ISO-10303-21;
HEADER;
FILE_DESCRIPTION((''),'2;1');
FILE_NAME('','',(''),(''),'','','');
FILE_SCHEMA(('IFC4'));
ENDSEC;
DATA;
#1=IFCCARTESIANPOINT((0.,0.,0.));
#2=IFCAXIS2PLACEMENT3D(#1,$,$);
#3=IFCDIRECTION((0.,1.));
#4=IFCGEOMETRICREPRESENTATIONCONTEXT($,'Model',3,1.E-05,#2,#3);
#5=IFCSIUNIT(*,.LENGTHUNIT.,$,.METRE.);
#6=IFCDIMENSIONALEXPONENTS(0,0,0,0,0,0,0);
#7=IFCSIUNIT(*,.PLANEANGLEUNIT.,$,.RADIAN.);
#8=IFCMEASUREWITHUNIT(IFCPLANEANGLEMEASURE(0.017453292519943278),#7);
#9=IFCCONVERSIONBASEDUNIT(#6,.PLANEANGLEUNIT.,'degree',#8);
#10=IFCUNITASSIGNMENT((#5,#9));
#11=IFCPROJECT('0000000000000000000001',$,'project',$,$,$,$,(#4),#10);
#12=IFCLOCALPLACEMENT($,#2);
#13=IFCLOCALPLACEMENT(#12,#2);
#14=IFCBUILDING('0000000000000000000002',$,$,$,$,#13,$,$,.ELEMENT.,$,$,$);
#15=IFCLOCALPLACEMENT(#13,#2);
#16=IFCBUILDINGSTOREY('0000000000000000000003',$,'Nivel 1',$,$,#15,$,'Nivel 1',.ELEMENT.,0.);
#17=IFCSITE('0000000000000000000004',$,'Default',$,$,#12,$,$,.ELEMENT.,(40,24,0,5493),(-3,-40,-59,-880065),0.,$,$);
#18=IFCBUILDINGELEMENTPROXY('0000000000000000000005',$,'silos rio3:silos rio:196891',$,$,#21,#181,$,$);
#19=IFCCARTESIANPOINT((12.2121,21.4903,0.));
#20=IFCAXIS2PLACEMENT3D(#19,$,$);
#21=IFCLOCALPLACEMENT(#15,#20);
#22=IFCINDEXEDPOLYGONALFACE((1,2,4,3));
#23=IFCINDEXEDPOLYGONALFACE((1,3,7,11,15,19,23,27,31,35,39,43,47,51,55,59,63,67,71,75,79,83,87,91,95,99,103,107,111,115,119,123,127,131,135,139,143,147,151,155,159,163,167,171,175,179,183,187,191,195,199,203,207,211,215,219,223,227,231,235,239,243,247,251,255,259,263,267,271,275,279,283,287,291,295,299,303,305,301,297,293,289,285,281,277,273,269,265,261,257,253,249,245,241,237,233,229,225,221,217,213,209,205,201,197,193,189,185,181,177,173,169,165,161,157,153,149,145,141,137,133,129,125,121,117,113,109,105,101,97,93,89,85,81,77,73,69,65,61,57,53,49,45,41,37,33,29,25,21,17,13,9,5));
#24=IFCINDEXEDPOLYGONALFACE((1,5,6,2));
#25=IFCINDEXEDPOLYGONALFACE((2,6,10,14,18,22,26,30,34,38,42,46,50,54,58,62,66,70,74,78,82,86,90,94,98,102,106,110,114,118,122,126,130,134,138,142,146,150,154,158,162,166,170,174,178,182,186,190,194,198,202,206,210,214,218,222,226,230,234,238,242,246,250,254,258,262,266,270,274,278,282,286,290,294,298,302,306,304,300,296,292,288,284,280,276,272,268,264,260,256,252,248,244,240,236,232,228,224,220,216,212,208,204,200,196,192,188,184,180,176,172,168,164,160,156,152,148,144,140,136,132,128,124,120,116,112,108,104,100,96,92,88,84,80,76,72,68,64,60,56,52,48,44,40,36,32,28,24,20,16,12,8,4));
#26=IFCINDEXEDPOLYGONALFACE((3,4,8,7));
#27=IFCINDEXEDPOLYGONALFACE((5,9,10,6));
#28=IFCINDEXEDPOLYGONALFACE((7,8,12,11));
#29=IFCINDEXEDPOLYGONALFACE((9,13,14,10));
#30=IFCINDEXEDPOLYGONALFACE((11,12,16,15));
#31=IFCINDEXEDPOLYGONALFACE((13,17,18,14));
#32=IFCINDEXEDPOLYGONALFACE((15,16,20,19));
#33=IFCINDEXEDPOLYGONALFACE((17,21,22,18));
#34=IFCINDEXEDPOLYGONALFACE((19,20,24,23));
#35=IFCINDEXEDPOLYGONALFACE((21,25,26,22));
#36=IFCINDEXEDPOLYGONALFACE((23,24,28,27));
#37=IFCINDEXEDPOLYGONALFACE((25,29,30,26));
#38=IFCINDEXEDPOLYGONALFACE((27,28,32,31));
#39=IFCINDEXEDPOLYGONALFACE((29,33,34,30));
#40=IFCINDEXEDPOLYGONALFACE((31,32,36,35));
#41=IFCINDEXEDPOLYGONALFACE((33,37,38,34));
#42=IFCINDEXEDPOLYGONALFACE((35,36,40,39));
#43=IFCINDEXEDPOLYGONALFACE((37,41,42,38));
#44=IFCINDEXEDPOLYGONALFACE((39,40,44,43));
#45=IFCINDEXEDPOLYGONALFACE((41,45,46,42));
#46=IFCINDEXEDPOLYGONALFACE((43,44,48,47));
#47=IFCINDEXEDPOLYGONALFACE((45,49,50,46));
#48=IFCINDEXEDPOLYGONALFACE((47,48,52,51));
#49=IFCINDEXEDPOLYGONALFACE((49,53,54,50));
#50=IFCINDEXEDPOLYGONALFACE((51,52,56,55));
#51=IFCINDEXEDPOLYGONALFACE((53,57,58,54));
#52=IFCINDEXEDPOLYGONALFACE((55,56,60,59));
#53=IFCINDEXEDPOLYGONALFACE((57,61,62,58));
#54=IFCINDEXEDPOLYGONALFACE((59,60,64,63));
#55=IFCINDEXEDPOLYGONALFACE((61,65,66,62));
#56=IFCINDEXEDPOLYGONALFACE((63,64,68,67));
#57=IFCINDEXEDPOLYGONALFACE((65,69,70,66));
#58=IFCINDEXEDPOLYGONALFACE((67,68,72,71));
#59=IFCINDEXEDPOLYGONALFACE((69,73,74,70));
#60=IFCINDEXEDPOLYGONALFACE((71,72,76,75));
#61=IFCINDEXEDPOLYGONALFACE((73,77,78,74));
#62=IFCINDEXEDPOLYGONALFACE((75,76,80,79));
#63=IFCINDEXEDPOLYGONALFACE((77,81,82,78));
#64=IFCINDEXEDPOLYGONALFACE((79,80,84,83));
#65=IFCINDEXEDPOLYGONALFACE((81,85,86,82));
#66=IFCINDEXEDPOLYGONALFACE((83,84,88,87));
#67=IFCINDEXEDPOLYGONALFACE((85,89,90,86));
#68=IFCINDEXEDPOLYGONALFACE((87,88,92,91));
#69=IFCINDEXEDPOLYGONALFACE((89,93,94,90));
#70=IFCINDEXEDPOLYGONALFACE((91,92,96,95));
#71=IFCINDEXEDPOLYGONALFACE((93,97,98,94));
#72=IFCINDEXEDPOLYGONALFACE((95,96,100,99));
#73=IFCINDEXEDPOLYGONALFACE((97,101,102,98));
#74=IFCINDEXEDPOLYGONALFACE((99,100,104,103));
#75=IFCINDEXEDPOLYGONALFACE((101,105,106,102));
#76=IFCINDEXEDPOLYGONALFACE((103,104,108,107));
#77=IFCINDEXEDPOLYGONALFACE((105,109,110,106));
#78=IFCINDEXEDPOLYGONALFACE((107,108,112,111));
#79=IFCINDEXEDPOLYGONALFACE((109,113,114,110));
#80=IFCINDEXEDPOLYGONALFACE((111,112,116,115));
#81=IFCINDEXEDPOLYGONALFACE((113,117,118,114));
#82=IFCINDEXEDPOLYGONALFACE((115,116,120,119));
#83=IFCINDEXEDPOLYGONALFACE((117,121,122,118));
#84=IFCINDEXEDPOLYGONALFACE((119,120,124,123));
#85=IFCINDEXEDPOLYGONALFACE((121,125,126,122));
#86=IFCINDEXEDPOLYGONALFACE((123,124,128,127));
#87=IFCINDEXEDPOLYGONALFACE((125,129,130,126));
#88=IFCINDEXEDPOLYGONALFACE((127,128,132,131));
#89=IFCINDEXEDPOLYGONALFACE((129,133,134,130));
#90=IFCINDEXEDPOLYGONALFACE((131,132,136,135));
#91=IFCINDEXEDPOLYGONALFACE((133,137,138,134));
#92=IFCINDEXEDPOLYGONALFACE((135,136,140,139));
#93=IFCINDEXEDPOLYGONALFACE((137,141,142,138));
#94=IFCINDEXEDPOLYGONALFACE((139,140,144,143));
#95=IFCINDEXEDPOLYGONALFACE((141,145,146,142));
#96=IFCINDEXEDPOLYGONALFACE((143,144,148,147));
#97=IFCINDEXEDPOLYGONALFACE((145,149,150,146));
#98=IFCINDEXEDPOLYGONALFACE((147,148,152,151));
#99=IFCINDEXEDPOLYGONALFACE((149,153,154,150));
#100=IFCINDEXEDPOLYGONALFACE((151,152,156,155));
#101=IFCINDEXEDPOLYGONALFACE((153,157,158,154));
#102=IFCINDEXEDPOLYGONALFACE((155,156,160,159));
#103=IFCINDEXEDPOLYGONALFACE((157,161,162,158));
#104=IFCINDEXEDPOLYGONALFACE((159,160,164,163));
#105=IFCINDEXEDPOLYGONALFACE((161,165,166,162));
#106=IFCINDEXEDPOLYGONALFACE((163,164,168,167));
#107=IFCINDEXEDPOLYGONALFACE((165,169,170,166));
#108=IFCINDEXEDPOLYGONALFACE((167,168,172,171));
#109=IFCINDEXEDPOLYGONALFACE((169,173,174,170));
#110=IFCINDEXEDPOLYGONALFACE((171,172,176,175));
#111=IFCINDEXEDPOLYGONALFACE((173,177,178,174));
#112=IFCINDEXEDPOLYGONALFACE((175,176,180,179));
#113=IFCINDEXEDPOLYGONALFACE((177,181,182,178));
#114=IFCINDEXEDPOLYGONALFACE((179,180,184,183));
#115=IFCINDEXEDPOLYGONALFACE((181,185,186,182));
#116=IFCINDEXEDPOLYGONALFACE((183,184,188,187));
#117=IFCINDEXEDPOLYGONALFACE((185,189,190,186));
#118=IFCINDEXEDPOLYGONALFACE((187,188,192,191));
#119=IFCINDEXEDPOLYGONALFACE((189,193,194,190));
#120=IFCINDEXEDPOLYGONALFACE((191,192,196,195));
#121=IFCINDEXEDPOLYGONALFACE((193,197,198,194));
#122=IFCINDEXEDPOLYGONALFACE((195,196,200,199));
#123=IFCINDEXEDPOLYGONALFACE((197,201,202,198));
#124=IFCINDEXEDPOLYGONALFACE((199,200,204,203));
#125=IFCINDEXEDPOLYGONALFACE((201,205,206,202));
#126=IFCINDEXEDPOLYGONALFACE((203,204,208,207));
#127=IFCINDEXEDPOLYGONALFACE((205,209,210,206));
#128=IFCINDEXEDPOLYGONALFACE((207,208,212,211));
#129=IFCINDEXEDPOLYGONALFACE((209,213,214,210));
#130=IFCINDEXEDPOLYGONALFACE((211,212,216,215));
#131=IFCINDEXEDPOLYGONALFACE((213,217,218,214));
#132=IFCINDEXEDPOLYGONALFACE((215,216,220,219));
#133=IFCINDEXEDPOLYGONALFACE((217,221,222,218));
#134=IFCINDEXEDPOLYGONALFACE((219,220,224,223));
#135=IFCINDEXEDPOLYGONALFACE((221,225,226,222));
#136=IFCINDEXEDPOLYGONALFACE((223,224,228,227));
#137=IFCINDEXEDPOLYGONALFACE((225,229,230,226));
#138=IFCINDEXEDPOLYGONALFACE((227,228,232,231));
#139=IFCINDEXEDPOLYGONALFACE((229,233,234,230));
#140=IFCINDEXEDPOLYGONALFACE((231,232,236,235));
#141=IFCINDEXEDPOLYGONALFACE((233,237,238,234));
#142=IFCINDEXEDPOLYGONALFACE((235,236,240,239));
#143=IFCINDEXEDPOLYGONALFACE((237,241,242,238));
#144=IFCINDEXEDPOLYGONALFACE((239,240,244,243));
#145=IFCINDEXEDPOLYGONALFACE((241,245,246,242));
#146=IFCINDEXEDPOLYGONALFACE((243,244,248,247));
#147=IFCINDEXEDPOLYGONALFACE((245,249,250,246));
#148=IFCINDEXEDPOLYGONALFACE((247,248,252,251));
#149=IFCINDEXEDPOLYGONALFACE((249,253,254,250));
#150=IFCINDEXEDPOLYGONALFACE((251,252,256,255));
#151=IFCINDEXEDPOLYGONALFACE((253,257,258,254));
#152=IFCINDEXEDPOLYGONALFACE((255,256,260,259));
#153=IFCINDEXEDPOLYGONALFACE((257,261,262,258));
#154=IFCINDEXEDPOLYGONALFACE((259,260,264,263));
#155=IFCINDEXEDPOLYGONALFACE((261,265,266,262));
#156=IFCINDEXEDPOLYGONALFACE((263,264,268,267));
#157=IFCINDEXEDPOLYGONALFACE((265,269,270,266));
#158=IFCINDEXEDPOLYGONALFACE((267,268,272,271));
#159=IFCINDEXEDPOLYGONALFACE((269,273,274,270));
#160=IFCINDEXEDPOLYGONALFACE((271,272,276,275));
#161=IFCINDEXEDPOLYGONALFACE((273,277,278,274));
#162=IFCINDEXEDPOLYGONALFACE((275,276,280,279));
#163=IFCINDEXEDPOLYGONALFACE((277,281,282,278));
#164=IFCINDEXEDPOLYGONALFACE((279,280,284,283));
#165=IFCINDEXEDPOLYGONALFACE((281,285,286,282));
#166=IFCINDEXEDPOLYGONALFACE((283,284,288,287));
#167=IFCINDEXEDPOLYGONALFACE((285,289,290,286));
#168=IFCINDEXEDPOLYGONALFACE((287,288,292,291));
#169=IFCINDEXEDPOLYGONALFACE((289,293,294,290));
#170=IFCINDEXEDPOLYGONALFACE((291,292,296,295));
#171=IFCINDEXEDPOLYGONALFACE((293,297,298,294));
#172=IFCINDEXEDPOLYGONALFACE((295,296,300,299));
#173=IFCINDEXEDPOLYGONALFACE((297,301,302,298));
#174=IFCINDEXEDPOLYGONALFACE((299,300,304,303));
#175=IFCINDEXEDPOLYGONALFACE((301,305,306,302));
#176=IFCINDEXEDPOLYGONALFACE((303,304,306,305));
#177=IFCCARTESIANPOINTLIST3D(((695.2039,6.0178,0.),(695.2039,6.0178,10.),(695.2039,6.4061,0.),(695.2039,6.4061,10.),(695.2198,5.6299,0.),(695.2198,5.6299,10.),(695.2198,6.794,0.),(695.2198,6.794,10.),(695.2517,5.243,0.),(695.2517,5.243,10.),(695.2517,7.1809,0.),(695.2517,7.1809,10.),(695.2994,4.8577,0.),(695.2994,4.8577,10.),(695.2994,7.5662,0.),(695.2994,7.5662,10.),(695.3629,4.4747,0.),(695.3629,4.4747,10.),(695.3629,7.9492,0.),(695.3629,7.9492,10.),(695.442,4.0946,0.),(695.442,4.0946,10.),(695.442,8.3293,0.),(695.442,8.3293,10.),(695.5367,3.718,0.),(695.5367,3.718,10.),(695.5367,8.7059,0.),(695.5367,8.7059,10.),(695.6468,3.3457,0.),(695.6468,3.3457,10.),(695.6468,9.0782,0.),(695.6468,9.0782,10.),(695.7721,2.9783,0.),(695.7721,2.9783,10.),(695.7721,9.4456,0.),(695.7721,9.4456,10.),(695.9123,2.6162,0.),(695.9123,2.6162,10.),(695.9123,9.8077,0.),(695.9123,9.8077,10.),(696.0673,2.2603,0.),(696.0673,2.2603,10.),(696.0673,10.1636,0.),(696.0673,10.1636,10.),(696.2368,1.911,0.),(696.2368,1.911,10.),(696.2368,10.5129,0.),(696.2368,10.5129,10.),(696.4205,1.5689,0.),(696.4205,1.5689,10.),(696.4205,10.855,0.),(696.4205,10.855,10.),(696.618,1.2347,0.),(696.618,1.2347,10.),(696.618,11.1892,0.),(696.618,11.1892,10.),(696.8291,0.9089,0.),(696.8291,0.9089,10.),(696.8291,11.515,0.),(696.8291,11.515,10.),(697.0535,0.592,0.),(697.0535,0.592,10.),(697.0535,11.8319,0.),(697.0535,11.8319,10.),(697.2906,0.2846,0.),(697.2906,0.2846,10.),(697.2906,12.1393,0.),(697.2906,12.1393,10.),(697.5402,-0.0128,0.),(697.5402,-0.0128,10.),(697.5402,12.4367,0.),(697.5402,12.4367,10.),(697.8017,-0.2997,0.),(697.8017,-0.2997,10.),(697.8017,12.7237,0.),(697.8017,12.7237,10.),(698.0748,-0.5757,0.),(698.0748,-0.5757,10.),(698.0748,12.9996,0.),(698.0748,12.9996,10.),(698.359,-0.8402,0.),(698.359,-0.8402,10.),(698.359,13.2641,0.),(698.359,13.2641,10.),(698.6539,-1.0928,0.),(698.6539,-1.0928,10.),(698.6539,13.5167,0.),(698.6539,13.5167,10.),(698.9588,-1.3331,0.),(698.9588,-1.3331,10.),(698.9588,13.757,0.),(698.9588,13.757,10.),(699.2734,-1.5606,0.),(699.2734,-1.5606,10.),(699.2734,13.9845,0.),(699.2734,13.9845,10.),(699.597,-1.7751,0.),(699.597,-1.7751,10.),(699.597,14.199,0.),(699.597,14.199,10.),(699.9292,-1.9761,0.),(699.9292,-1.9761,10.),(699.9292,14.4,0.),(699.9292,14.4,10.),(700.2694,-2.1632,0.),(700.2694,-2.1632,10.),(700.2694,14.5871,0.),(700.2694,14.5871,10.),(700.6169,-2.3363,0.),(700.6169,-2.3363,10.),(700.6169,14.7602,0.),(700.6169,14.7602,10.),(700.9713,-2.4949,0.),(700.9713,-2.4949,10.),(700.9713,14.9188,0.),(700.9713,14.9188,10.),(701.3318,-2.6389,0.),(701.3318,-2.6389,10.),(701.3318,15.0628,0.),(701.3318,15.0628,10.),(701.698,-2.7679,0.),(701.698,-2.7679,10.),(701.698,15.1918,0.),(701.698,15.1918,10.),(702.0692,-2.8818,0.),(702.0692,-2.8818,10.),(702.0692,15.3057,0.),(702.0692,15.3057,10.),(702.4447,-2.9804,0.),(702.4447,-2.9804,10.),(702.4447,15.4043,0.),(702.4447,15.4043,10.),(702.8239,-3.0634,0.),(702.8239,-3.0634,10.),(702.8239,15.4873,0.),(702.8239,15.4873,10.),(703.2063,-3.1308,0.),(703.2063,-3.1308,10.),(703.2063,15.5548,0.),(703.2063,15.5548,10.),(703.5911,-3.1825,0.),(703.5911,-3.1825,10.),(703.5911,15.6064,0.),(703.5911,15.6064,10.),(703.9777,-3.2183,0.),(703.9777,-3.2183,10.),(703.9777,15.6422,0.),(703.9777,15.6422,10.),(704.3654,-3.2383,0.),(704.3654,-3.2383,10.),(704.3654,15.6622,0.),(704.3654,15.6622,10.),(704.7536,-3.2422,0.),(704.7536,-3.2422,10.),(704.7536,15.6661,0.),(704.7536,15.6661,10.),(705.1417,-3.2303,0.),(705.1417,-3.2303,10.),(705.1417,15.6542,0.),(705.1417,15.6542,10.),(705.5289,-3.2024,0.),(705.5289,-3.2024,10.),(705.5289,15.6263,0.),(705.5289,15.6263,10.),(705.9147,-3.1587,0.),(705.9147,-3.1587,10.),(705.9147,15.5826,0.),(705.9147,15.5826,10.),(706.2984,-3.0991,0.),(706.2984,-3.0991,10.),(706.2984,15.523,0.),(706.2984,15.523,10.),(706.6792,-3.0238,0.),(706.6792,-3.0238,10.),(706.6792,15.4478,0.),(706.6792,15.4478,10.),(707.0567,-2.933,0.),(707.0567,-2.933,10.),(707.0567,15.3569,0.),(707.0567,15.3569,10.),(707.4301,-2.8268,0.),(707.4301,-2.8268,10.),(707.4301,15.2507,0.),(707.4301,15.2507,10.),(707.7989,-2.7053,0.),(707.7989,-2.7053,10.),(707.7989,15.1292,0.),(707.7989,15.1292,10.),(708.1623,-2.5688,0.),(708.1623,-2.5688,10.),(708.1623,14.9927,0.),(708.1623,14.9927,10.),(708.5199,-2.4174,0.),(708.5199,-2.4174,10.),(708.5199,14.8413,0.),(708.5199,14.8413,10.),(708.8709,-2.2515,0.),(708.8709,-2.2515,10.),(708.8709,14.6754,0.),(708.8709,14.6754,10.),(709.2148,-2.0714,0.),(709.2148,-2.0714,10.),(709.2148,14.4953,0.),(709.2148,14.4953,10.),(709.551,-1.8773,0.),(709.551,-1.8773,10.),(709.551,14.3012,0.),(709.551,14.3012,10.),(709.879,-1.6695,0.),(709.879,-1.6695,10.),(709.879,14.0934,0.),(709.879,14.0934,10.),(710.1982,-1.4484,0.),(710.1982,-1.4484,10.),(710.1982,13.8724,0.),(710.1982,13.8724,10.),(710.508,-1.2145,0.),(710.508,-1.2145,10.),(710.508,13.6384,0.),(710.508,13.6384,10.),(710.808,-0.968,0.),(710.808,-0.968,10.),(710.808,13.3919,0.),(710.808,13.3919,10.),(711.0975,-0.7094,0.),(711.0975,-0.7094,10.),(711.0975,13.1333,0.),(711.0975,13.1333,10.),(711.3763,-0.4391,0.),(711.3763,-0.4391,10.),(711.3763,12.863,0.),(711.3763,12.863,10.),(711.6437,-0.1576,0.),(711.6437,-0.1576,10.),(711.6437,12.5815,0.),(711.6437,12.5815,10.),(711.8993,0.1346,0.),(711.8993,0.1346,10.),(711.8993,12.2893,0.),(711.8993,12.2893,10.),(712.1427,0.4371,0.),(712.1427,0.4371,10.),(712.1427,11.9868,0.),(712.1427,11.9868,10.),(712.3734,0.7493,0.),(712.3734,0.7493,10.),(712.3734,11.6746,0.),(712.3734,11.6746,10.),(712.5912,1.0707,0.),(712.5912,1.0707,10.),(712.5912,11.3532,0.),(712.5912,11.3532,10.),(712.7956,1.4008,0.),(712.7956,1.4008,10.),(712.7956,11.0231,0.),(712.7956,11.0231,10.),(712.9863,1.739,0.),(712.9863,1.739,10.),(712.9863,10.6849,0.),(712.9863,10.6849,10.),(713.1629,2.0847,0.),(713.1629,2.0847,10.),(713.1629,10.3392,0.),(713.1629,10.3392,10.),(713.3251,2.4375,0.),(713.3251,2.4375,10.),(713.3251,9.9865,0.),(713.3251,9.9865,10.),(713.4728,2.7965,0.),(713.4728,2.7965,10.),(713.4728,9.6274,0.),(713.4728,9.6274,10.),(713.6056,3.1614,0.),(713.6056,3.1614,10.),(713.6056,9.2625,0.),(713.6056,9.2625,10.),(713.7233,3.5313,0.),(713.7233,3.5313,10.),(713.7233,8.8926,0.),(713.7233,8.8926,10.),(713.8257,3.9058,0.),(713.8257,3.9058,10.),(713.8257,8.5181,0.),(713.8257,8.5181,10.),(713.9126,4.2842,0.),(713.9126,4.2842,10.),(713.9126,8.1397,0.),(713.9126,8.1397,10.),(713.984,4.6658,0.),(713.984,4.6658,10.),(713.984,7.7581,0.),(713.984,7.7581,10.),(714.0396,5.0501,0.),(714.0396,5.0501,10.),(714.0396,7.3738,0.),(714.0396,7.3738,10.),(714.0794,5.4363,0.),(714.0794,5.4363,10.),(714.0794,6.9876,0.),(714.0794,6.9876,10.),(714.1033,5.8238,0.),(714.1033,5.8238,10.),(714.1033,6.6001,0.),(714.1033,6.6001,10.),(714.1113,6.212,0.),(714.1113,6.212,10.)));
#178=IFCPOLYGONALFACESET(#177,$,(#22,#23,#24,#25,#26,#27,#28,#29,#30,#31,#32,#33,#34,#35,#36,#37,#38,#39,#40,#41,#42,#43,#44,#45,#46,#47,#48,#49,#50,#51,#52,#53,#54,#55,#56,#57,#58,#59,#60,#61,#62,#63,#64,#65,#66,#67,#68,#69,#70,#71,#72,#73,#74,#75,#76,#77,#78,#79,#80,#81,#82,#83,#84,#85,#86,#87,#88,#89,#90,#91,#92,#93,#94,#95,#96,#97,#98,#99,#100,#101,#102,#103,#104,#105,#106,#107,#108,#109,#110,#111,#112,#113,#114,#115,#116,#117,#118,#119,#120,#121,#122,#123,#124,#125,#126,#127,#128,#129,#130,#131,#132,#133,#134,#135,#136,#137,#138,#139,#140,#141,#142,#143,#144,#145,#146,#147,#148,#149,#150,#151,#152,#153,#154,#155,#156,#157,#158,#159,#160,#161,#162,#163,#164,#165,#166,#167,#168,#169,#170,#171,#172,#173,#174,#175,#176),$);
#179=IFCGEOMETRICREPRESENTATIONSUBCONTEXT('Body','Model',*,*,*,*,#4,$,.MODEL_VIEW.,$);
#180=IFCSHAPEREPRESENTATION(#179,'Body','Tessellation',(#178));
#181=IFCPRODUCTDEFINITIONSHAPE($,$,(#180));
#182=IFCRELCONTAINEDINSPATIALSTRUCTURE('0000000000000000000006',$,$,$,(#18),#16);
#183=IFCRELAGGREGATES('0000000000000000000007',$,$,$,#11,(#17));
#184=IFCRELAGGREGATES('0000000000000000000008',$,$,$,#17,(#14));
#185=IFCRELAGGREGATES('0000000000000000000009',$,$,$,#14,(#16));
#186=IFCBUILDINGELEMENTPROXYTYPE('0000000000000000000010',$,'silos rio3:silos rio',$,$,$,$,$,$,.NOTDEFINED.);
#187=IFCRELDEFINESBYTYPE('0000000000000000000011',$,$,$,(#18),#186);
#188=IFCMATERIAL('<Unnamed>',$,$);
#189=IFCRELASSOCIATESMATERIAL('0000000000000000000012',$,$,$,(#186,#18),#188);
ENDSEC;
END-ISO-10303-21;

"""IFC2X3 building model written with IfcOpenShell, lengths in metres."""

from ifc_helpers import new_model, entity, si_unit, converted_unit, direction, frame, frame_2d, origin, place, context, subcontext, project, spatial, circle, extrude, source, transform, mapped, material, type_object, type_shapes, element, save


model = new_model("IFC2X3")

# Units and contexts
model_context = context("Model", 3, precision=1e-05, world=origin(), true_north=direction((0.0, 1.0)))
body_context = subcontext(model_context, "Body", "Model", "MODEL_VIEW")
ifc_project = project(units=[si_unit("LENGTHUNIT", "METRE"), converted_unit("PLANEANGLEUNIT", "degree", entity("IfcPlaneAngleMeasure", 0.017453292519943278), si_unit("PLANEANGLEUNIT", "RADIAN"), dimensions=[0, 0, 0, 0, 0, 0, 0])], contexts=[model_context])

# Site, building, storey
site_placement = place(None, origin())
site = spatial("IfcSite", under=ifc_project, at=site_placement, Name="Default", CompositionType="ELEMENT", RefLatitude=(40, 24, 0, 5493), RefLongitude=(-3, -40, -59, -880065), RefElevation=0.0)
building_placement = place(site_placement, origin())
building = spatial("IfcBuilding", under=site, at=building_placement, CompositionType="ELEMENT")
storey_placement = place(building_placement, origin())
storey = spatial("IfcBuildingStorey", under=building, at=storey_placement, Name="Nivel 1", LongName="Nivel 1", CompositionType="ELEMENT", Elevation=0.0)

# Building element proxy
ifc_material_1 = material(Name="<Unnamed>")
building_element_proxy_type_1 = type_object("IfcBuildingElementProxyType", Name="silos rio3:silos rio", PredefinedType="NOTDEFINED", material=ifc_material_1)
shared_shape_1 = source(origin(), body_context, "Body", "SweptSolid", [
    extrude(circle(Radius=9.4547, at=frame_2d((0.0, 0.0), x_axis=(1.0, 0.0))), frame((704.6566, 6.212, 0.0)), (0.0, 0.0, 1.0), 10.0),
])
type_shapes(building_element_proxy_type_1, [shared_shape_1])
proxy_1_placement = place(storey_placement, frame((12.2121, 21.4903, 0.0)))
element("IfcBuildingElementProxy", 1, at=proxy_1_placement, inside=storey, type_object=building_element_proxy_type_1, material=ifc_material_1, Name="silos rio3:silos rio:196891", context=body_context, shape_type="MappedRepresentation", body=[
    mapped(shared_shape_1, transform((0.0, 0.0, 0.0), scale=1.0)),
])

save(model, "model.ifc")
